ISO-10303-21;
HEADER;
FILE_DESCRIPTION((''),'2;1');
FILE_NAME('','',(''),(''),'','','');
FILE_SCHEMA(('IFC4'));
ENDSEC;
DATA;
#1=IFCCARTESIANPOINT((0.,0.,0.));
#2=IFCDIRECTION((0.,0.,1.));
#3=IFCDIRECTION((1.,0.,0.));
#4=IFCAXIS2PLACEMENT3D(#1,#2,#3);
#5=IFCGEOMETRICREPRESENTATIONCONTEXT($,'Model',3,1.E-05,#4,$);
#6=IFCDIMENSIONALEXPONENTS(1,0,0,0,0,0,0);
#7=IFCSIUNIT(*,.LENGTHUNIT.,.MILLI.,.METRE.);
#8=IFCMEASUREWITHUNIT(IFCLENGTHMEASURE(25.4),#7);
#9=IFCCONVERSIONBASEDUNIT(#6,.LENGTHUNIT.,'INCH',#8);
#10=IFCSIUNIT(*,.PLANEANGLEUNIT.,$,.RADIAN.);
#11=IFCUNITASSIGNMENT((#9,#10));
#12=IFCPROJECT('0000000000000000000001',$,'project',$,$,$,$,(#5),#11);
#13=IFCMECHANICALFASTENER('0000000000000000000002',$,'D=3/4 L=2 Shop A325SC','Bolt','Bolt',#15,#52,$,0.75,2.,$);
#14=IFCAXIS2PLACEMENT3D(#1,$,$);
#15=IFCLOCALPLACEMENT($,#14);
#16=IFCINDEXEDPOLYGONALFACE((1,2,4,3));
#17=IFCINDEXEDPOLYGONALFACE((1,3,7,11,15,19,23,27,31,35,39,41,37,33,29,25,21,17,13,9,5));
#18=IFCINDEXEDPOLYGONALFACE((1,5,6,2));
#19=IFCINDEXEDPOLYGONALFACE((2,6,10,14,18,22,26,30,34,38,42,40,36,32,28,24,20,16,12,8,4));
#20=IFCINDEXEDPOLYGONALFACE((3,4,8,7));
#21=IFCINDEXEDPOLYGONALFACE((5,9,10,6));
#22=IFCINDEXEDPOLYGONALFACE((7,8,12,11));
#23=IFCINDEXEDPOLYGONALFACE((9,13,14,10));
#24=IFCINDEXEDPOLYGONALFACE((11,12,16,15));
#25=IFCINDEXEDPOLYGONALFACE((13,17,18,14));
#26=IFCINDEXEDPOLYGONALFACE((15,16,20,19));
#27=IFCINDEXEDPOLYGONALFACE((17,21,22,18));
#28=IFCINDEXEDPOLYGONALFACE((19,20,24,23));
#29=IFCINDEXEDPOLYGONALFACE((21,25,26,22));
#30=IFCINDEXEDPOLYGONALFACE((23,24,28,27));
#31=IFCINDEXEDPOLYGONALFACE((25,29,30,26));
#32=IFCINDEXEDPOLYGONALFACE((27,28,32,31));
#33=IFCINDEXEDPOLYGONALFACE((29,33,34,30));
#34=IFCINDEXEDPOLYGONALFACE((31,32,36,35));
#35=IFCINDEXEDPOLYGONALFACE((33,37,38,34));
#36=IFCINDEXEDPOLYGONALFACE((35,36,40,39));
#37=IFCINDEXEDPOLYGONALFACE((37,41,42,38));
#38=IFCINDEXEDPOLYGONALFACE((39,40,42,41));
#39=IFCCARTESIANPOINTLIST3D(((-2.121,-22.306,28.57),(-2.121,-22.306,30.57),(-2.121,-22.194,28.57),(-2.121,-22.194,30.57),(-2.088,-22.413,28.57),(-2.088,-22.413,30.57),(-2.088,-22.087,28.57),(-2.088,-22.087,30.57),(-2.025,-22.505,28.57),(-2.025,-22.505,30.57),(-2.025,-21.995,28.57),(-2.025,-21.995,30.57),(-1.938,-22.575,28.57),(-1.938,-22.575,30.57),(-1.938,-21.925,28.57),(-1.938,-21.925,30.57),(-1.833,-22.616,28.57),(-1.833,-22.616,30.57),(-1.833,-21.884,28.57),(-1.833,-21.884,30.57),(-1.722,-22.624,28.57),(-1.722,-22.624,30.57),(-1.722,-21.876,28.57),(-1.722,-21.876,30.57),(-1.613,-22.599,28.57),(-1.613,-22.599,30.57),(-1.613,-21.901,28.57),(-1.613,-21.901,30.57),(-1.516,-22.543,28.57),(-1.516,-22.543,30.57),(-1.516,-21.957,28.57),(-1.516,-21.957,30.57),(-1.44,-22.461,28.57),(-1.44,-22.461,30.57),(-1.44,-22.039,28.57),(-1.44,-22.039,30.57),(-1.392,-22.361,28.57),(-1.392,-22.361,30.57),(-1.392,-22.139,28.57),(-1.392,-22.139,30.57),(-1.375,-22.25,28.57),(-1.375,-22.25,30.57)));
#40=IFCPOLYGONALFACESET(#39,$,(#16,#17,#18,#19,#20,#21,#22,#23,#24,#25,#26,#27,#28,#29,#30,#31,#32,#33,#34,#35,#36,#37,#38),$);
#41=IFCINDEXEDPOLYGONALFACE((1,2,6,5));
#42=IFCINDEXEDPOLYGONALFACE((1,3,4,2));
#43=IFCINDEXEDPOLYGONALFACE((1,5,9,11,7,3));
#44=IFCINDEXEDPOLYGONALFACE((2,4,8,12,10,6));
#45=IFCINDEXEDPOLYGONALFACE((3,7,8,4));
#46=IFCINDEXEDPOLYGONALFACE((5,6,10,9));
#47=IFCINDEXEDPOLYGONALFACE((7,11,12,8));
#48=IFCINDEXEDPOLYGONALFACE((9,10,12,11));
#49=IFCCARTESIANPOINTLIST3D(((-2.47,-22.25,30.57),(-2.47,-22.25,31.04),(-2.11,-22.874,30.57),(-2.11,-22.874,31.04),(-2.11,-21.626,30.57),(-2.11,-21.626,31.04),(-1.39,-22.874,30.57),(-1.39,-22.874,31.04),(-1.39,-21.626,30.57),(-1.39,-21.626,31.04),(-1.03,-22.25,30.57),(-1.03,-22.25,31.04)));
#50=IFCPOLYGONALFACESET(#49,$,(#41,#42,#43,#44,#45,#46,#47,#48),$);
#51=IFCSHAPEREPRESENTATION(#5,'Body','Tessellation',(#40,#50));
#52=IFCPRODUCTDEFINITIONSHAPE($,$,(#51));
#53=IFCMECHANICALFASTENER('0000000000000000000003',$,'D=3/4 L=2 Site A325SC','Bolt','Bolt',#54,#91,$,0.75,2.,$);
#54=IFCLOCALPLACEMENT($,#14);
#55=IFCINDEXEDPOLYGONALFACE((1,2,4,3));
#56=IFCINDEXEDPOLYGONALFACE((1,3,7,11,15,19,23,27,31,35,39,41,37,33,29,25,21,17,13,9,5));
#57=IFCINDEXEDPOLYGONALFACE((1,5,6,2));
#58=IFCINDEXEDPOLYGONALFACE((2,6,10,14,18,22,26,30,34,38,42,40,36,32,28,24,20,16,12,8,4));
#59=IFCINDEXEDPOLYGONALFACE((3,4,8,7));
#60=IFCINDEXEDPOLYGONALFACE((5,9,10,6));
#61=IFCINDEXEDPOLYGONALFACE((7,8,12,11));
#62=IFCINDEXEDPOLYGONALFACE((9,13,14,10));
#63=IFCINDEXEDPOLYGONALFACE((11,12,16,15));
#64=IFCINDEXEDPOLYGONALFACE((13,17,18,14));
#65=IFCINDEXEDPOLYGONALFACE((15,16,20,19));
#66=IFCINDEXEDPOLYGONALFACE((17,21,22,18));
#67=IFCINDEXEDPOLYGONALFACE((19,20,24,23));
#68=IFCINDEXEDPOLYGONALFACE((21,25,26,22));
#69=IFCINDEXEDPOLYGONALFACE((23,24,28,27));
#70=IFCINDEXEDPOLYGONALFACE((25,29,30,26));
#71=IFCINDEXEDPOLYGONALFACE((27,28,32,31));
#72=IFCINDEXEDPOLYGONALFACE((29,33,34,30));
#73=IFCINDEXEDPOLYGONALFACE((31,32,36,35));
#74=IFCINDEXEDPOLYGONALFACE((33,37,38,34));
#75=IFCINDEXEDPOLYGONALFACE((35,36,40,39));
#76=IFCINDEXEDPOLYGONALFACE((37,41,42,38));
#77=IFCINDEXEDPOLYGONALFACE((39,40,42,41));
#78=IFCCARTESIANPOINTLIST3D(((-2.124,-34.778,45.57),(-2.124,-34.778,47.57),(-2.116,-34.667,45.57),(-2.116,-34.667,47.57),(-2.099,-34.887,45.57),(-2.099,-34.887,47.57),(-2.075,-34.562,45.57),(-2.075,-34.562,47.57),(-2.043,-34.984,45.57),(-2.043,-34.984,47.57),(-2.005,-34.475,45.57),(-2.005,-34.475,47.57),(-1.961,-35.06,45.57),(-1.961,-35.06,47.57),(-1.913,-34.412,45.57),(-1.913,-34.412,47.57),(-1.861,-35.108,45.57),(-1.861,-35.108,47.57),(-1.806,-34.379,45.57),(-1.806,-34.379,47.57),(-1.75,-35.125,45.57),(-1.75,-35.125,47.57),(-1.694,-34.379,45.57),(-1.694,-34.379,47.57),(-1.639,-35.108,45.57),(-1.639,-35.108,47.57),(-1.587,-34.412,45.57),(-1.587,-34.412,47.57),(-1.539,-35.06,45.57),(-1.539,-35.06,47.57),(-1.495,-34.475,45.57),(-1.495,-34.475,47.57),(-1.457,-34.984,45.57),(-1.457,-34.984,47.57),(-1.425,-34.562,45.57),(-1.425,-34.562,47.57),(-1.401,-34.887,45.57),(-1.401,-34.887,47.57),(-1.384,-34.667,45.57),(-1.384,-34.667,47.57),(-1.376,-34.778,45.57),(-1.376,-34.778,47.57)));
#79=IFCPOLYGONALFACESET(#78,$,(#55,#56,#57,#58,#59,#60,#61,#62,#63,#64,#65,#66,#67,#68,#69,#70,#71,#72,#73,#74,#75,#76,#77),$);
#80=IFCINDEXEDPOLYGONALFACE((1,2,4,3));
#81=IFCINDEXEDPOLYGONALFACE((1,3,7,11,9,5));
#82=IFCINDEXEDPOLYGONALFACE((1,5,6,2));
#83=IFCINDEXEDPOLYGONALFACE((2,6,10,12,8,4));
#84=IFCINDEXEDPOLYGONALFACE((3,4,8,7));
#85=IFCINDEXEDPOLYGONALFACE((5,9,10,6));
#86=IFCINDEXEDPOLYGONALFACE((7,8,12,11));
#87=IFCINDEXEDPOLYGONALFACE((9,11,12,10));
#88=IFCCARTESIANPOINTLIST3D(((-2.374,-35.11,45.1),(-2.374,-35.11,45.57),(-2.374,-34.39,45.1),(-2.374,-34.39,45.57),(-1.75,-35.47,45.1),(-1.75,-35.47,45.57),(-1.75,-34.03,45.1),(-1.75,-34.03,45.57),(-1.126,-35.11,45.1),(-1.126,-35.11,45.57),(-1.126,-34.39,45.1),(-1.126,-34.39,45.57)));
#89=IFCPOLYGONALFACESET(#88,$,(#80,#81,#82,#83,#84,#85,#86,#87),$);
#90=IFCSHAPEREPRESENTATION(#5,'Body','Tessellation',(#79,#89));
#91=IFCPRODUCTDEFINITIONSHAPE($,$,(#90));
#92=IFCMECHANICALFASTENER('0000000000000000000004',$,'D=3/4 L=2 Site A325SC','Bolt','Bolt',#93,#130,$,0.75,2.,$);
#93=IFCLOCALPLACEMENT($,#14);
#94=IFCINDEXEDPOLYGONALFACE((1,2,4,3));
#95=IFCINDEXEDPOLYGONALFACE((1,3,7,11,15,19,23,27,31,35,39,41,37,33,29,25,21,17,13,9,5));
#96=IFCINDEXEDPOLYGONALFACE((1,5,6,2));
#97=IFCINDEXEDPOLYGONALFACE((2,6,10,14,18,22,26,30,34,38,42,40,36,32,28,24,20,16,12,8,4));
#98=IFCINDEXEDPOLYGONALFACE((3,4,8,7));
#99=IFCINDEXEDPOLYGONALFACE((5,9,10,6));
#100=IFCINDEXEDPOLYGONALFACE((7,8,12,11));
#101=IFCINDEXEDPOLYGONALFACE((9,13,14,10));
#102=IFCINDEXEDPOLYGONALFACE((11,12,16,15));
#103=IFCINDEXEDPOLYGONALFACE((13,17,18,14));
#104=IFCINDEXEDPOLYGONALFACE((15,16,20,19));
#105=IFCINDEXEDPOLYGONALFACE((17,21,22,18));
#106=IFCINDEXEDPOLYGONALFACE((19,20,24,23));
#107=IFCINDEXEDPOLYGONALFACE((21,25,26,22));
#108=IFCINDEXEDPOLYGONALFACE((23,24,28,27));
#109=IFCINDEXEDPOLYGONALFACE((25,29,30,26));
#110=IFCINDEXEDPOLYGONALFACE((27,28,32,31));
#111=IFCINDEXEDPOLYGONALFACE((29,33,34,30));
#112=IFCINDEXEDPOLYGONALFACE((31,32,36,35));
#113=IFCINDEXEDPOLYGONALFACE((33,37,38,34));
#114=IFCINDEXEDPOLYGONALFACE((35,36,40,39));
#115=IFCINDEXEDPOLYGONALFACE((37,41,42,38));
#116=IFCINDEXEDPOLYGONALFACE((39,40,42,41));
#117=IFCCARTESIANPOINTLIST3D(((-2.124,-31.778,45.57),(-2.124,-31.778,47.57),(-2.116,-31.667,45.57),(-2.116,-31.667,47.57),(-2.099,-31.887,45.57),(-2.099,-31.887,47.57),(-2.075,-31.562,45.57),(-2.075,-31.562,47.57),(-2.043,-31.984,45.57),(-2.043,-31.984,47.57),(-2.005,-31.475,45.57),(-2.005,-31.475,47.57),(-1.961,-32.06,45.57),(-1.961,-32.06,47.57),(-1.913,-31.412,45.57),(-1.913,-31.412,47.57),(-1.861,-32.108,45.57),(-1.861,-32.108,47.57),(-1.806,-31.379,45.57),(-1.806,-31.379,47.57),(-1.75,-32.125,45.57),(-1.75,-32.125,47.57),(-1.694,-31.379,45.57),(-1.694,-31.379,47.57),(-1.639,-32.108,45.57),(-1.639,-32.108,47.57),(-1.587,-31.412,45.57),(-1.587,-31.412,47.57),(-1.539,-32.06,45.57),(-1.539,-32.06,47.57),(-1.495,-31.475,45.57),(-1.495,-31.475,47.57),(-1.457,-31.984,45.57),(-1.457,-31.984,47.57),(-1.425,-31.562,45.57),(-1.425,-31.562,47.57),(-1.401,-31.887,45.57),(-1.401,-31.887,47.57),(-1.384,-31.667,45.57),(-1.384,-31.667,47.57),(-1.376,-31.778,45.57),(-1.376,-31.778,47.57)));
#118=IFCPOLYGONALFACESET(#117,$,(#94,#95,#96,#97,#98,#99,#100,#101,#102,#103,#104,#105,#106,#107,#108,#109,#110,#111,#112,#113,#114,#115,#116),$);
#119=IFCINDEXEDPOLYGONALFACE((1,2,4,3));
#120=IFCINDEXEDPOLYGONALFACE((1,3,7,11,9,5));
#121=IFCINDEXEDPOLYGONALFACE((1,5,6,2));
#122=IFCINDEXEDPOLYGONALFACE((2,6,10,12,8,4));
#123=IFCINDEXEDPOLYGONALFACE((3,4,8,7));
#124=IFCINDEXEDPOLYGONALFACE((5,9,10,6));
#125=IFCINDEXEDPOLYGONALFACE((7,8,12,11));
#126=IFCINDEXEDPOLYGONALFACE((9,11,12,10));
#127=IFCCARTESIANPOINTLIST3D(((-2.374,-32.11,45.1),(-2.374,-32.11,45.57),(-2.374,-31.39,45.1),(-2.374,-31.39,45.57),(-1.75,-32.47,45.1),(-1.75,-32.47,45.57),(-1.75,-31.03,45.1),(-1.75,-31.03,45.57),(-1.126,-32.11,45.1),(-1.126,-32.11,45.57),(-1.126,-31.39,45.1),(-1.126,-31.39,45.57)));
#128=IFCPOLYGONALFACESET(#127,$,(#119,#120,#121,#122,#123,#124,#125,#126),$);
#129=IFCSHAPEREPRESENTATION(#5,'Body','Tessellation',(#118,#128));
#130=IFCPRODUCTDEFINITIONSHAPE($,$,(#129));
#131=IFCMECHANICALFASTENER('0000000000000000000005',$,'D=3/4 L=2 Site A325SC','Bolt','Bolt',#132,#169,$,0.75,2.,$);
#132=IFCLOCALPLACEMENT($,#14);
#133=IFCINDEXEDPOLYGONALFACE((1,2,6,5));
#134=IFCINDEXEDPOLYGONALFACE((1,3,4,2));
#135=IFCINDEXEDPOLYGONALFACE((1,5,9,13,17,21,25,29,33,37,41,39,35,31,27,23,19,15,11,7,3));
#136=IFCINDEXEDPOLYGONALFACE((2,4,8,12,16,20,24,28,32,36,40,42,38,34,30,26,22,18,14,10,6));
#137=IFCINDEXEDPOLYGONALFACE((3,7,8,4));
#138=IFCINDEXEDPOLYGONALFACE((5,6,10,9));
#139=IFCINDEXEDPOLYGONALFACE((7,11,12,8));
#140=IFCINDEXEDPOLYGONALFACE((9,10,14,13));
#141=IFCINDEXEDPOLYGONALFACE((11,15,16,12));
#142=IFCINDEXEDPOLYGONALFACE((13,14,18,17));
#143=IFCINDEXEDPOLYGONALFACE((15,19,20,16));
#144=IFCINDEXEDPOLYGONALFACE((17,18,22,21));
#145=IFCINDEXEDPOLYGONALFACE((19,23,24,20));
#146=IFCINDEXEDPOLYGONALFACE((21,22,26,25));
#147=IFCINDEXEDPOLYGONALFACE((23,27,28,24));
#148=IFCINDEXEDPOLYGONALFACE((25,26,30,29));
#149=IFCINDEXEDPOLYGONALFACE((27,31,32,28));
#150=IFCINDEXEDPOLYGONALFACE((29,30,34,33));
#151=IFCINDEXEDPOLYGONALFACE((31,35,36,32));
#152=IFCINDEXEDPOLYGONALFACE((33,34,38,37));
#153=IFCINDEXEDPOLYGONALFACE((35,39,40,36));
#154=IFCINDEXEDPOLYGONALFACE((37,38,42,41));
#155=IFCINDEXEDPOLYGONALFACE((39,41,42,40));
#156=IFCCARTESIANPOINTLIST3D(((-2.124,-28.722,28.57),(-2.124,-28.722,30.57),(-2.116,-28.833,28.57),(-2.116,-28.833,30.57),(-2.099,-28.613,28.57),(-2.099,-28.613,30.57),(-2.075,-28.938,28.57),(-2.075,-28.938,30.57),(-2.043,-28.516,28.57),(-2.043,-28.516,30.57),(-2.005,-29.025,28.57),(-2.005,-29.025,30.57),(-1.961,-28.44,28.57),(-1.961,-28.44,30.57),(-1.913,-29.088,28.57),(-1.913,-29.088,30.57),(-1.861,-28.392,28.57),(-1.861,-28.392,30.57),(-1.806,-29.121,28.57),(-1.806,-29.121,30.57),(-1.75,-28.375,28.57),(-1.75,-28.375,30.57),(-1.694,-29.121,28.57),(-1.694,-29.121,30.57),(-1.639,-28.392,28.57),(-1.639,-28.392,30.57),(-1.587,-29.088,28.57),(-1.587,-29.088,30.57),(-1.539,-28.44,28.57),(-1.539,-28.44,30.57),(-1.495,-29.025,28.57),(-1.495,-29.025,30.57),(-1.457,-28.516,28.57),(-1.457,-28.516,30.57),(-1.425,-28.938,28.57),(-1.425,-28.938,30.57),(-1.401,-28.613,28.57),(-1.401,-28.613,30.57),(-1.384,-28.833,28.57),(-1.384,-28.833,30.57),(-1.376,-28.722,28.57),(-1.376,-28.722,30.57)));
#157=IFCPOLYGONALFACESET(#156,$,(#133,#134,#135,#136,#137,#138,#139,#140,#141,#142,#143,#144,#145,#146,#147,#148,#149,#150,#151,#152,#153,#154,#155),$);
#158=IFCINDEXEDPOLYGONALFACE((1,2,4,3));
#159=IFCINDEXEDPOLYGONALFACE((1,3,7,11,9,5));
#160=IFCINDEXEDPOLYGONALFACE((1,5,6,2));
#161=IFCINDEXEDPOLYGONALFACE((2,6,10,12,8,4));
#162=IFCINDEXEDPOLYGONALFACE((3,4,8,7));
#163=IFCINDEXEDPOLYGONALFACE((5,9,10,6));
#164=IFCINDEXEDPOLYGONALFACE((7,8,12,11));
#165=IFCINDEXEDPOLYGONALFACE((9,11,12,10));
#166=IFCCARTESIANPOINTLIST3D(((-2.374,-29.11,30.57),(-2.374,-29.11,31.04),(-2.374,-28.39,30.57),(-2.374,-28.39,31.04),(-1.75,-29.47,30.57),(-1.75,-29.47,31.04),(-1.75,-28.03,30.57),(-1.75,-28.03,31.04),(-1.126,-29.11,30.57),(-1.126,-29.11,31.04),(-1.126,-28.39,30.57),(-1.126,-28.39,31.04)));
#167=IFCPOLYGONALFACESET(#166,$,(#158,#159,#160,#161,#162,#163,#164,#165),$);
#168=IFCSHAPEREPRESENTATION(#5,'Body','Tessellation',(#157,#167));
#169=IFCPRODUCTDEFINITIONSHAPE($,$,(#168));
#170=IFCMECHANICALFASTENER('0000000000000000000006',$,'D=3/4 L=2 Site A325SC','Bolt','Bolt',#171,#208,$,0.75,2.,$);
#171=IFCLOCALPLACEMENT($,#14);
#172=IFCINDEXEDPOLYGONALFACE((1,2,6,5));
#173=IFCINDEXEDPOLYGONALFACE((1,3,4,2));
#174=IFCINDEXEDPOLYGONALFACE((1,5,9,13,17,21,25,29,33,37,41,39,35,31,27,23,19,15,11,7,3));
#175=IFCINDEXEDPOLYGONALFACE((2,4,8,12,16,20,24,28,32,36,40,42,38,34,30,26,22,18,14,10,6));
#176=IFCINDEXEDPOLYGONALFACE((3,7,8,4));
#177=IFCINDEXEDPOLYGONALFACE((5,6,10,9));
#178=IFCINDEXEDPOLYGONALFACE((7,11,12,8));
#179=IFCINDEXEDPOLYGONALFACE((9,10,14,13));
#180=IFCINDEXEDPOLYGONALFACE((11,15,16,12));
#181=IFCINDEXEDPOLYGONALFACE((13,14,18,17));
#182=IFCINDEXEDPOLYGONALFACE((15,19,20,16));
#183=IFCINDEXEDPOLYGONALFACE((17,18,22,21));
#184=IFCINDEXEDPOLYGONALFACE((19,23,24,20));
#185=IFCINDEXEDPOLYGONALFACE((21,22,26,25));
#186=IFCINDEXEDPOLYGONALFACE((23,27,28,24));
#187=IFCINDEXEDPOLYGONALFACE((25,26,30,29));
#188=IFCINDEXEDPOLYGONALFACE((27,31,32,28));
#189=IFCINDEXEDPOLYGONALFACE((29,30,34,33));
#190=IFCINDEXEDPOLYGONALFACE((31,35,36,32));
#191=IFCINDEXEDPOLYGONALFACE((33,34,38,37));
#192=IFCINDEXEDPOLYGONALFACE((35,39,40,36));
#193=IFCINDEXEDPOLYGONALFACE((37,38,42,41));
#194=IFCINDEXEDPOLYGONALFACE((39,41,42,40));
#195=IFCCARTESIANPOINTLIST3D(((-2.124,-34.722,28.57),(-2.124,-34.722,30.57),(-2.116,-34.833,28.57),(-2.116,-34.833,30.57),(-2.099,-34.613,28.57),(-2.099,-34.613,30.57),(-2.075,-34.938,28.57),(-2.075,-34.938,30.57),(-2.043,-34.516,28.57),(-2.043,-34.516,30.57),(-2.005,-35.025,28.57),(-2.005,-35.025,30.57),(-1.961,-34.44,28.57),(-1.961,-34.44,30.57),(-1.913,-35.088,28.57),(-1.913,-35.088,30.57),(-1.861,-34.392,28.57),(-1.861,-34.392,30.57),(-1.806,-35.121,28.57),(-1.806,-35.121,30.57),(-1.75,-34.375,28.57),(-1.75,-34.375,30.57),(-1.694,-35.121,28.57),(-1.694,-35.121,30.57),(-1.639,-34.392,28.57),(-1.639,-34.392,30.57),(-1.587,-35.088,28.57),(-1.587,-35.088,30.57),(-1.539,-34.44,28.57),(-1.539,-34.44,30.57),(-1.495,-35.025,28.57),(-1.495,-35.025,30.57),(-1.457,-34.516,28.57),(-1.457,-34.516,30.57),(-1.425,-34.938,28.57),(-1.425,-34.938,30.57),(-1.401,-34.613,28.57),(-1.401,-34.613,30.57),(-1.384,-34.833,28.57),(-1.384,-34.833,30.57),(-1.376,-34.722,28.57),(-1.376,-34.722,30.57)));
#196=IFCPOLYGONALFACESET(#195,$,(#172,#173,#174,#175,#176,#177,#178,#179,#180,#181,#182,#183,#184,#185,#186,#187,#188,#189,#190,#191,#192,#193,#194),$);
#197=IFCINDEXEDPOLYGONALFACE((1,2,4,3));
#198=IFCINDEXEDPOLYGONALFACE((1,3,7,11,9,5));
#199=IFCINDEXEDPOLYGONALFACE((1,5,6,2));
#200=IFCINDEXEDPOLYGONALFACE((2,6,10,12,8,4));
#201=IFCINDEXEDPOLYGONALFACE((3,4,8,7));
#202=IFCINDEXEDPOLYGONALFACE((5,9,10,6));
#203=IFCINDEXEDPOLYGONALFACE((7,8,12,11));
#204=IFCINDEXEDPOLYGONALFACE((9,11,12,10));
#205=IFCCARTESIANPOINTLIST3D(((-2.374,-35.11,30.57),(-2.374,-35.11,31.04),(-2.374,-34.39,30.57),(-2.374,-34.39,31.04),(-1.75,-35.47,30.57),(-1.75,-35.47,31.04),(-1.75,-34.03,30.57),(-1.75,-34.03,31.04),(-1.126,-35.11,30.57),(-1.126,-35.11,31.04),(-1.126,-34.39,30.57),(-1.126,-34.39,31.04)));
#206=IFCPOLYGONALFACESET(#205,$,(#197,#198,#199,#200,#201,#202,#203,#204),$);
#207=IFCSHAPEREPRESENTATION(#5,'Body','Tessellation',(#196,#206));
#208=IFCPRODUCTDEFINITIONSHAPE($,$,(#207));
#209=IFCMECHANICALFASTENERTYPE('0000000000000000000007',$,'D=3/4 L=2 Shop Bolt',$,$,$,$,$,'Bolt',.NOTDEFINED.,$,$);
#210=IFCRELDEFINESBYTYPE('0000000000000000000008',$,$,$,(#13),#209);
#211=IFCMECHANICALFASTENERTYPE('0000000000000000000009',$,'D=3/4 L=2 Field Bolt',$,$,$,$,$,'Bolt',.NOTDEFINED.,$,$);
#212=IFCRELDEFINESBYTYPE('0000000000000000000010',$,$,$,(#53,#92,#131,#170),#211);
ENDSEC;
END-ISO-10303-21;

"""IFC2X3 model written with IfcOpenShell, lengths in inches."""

from ifc_helpers import new_model, entity, si_unit, converted_unit, frame, origin_with_axes, origin_2d_with_axis, place, context, project, polyline, circle, outline, extrude, source, transform, mapped, type_object, type_shapes, element, save


model = new_model("IFC2X3")

# Units and contexts
model_context = context("Model", 3, precision=1e-05, world=origin_with_axes())
ifc_project = project(units=[converted_unit("LENGTHUNIT", "INCH", entity("IfcLengthMeasure", 25.4), si_unit("LENGTHUNIT", "METRE", prefix="MILLI"), dimensions=[1, 0, 0, 0, 0, 0, 0]), si_unit("PLANEANGLEUNIT", "RADIAN")], contexts=[model_context])

# Mechanical fasteners
placement_1 = place(None, origin_with_axes())
placement_2 = place(placement_1, origin_with_axes())
mechanical_fastener_type_1 = type_object("IfcMechanicalFastenerType", Name="D=3/4 L=2 Shop Bolt", ElementType="Bolt")
shared_shape_1 = source(origin_with_axes(), model_context, "Body", "SweptSolid", [
    extrude(circle(Radius=0.375, at=origin_2d_with_axis()), frame((0.0, 0.0, 0.0), z_axis=(1.0, 0.0, 0.0), x_axis=(0.0, 1.0, 0.0)), (0.0, 0.0, 1.0), 2.0),
    extrude(outline(polyline([(-0.72, 0.0), (-0.36, 0.624), (0.36, 0.624), (0.72, 0.0), (0.36, -0.624), (-0.36, -0.624), (-0.72, 0.0)])), frame((0.0, 0.0, 0.0), z_axis=(1.0, 0.0, 0.0), x_axis=(0.0, 1.0, 0.0)), (0.0, 0.0, -1.0), 0.47),
])
type_shapes(mechanical_fastener_type_1, [shared_shape_1])
placement_3 = place(placement_2, frame((0.0, 0.0, 46.0), z_axis=(0.0, 0.0, 1.0), x_axis=(0.0, -1.0, 0.0)))
placement_4 = place(placement_3, frame((25.25, -1.75, -15.43), z_axis=(1.0, 0.0, 0.0), x_axis=(0.0, 0.0, -1.0)))
for number, where, z_axis, x_axis, name in (
    (1, (0.0, 0.0, -3.0), (0.0, 0.0, 1.0), (1.0, 0.0, 0.0), "D=3/4 L=2 Shop A325SC"),
):
    element("IfcMechanicalFastener", number, at=place(placement_4, frame(where, z_axis=z_axis, x_axis=x_axis)), type_object=mechanical_fastener_type_1, Name=name, Description="Bolt", ObjectType="Bolt", NominalDiameter=0.75, NominalLength=2.0, context=model_context, shape_type="MappedRepresentation", body=[
        mapped(shared_shape_1, transform((0.0, 0.0, 0.0), scale=1.0)),
    ])
mechanical_fastener_type_2 = type_object("IfcMechanicalFastenerType", Name="D=3/4 L=2 Field Bolt", ElementType="Bolt")
shared_shape_2 = source(origin_with_axes(), model_context, "Body", "SweptSolid", [
    extrude(circle(Radius=0.375, at=origin_2d_with_axis()), frame((0.0, 0.0, 0.0), z_axis=(1.0, 0.0, 0.0), x_axis=(0.0, 1.0, 0.0)), (0.0, 0.0, 1.0), 2.0),
    extrude(outline(polyline([(-0.72, 0.0), (-0.36, 0.624), (0.36, 0.624), (0.72, 0.0), (0.36, -0.624), (-0.36, -0.624), (-0.72, 0.0)])), frame((0.0, 0.0, 0.0), z_axis=(1.0, 0.0, 0.0), x_axis=(0.0, 1.0, 0.0)), (0.0, 0.0, -1.0), 0.47),
])
type_shapes(mechanical_fastener_type_2, [shared_shape_2])
placement_5 = place(placement_3, frame((28.75, -1.75, -0.43), z_axis=(0.0, 1.0, 0.0), x_axis=(0.0, 0.0, 1.0)))
for number, where, z_axis, x_axis, name in (
    (2, (0.0, 6.0, 0.0), (0.0, 0.0, 1.0), (1.0, 0.0, 0.0), "D=3/4 L=2 Site A325SC"),
    (3, (0.0, 3.0, 0.0), (0.0, 0.0, 1.0), (1.0, 0.0, 0.0), "D=3/4 L=2 Site A325SC"),
):
    element("IfcMechanicalFastener", number, at=place(placement_5, frame(where, z_axis=z_axis, x_axis=x_axis)), type_object=mechanical_fastener_type_2, Name=name, Description="Bolt", ObjectType="Bolt", NominalDiameter=0.75, NominalLength=2.0, context=model_context, shape_type="MappedRepresentation", body=[
        mapped(shared_shape_2, transform((0.0, 0.0, 0.0), scale=1.0)),
    ])
placement_6 = place(placement_3, frame((28.75, -1.75, -15.43), z_axis=(0.0, 1.0, 0.0), x_axis=(0.0, 0.0, -1.0)))
for number, where, z_axis, x_axis, name in (
    (4, (0.0, 0.0, 0.0), (0.0, 0.0, 1.0), (1.0, 0.0, 0.0), "D=3/4 L=2 Site A325SC"),
    (5, (0.0, -6.0, 0.0), (0.0, 0.0, 1.0), (1.0, 0.0, 0.0), "D=3/4 L=2 Site A325SC"),
):
    element("IfcMechanicalFastener", number, at=place(placement_6, frame(where, z_axis=z_axis, x_axis=x_axis)), type_object=mechanical_fastener_type_2, Name=name, Description="Bolt", ObjectType="Bolt", NominalDiameter=0.75, NominalLength=2.0, context=model_context, shape_type="MappedRepresentation", body=[
        mapped(shared_shape_2, transform((0.0, 0.0, 0.0), scale=1.0)),
    ])

save(model, "model.ifc")
